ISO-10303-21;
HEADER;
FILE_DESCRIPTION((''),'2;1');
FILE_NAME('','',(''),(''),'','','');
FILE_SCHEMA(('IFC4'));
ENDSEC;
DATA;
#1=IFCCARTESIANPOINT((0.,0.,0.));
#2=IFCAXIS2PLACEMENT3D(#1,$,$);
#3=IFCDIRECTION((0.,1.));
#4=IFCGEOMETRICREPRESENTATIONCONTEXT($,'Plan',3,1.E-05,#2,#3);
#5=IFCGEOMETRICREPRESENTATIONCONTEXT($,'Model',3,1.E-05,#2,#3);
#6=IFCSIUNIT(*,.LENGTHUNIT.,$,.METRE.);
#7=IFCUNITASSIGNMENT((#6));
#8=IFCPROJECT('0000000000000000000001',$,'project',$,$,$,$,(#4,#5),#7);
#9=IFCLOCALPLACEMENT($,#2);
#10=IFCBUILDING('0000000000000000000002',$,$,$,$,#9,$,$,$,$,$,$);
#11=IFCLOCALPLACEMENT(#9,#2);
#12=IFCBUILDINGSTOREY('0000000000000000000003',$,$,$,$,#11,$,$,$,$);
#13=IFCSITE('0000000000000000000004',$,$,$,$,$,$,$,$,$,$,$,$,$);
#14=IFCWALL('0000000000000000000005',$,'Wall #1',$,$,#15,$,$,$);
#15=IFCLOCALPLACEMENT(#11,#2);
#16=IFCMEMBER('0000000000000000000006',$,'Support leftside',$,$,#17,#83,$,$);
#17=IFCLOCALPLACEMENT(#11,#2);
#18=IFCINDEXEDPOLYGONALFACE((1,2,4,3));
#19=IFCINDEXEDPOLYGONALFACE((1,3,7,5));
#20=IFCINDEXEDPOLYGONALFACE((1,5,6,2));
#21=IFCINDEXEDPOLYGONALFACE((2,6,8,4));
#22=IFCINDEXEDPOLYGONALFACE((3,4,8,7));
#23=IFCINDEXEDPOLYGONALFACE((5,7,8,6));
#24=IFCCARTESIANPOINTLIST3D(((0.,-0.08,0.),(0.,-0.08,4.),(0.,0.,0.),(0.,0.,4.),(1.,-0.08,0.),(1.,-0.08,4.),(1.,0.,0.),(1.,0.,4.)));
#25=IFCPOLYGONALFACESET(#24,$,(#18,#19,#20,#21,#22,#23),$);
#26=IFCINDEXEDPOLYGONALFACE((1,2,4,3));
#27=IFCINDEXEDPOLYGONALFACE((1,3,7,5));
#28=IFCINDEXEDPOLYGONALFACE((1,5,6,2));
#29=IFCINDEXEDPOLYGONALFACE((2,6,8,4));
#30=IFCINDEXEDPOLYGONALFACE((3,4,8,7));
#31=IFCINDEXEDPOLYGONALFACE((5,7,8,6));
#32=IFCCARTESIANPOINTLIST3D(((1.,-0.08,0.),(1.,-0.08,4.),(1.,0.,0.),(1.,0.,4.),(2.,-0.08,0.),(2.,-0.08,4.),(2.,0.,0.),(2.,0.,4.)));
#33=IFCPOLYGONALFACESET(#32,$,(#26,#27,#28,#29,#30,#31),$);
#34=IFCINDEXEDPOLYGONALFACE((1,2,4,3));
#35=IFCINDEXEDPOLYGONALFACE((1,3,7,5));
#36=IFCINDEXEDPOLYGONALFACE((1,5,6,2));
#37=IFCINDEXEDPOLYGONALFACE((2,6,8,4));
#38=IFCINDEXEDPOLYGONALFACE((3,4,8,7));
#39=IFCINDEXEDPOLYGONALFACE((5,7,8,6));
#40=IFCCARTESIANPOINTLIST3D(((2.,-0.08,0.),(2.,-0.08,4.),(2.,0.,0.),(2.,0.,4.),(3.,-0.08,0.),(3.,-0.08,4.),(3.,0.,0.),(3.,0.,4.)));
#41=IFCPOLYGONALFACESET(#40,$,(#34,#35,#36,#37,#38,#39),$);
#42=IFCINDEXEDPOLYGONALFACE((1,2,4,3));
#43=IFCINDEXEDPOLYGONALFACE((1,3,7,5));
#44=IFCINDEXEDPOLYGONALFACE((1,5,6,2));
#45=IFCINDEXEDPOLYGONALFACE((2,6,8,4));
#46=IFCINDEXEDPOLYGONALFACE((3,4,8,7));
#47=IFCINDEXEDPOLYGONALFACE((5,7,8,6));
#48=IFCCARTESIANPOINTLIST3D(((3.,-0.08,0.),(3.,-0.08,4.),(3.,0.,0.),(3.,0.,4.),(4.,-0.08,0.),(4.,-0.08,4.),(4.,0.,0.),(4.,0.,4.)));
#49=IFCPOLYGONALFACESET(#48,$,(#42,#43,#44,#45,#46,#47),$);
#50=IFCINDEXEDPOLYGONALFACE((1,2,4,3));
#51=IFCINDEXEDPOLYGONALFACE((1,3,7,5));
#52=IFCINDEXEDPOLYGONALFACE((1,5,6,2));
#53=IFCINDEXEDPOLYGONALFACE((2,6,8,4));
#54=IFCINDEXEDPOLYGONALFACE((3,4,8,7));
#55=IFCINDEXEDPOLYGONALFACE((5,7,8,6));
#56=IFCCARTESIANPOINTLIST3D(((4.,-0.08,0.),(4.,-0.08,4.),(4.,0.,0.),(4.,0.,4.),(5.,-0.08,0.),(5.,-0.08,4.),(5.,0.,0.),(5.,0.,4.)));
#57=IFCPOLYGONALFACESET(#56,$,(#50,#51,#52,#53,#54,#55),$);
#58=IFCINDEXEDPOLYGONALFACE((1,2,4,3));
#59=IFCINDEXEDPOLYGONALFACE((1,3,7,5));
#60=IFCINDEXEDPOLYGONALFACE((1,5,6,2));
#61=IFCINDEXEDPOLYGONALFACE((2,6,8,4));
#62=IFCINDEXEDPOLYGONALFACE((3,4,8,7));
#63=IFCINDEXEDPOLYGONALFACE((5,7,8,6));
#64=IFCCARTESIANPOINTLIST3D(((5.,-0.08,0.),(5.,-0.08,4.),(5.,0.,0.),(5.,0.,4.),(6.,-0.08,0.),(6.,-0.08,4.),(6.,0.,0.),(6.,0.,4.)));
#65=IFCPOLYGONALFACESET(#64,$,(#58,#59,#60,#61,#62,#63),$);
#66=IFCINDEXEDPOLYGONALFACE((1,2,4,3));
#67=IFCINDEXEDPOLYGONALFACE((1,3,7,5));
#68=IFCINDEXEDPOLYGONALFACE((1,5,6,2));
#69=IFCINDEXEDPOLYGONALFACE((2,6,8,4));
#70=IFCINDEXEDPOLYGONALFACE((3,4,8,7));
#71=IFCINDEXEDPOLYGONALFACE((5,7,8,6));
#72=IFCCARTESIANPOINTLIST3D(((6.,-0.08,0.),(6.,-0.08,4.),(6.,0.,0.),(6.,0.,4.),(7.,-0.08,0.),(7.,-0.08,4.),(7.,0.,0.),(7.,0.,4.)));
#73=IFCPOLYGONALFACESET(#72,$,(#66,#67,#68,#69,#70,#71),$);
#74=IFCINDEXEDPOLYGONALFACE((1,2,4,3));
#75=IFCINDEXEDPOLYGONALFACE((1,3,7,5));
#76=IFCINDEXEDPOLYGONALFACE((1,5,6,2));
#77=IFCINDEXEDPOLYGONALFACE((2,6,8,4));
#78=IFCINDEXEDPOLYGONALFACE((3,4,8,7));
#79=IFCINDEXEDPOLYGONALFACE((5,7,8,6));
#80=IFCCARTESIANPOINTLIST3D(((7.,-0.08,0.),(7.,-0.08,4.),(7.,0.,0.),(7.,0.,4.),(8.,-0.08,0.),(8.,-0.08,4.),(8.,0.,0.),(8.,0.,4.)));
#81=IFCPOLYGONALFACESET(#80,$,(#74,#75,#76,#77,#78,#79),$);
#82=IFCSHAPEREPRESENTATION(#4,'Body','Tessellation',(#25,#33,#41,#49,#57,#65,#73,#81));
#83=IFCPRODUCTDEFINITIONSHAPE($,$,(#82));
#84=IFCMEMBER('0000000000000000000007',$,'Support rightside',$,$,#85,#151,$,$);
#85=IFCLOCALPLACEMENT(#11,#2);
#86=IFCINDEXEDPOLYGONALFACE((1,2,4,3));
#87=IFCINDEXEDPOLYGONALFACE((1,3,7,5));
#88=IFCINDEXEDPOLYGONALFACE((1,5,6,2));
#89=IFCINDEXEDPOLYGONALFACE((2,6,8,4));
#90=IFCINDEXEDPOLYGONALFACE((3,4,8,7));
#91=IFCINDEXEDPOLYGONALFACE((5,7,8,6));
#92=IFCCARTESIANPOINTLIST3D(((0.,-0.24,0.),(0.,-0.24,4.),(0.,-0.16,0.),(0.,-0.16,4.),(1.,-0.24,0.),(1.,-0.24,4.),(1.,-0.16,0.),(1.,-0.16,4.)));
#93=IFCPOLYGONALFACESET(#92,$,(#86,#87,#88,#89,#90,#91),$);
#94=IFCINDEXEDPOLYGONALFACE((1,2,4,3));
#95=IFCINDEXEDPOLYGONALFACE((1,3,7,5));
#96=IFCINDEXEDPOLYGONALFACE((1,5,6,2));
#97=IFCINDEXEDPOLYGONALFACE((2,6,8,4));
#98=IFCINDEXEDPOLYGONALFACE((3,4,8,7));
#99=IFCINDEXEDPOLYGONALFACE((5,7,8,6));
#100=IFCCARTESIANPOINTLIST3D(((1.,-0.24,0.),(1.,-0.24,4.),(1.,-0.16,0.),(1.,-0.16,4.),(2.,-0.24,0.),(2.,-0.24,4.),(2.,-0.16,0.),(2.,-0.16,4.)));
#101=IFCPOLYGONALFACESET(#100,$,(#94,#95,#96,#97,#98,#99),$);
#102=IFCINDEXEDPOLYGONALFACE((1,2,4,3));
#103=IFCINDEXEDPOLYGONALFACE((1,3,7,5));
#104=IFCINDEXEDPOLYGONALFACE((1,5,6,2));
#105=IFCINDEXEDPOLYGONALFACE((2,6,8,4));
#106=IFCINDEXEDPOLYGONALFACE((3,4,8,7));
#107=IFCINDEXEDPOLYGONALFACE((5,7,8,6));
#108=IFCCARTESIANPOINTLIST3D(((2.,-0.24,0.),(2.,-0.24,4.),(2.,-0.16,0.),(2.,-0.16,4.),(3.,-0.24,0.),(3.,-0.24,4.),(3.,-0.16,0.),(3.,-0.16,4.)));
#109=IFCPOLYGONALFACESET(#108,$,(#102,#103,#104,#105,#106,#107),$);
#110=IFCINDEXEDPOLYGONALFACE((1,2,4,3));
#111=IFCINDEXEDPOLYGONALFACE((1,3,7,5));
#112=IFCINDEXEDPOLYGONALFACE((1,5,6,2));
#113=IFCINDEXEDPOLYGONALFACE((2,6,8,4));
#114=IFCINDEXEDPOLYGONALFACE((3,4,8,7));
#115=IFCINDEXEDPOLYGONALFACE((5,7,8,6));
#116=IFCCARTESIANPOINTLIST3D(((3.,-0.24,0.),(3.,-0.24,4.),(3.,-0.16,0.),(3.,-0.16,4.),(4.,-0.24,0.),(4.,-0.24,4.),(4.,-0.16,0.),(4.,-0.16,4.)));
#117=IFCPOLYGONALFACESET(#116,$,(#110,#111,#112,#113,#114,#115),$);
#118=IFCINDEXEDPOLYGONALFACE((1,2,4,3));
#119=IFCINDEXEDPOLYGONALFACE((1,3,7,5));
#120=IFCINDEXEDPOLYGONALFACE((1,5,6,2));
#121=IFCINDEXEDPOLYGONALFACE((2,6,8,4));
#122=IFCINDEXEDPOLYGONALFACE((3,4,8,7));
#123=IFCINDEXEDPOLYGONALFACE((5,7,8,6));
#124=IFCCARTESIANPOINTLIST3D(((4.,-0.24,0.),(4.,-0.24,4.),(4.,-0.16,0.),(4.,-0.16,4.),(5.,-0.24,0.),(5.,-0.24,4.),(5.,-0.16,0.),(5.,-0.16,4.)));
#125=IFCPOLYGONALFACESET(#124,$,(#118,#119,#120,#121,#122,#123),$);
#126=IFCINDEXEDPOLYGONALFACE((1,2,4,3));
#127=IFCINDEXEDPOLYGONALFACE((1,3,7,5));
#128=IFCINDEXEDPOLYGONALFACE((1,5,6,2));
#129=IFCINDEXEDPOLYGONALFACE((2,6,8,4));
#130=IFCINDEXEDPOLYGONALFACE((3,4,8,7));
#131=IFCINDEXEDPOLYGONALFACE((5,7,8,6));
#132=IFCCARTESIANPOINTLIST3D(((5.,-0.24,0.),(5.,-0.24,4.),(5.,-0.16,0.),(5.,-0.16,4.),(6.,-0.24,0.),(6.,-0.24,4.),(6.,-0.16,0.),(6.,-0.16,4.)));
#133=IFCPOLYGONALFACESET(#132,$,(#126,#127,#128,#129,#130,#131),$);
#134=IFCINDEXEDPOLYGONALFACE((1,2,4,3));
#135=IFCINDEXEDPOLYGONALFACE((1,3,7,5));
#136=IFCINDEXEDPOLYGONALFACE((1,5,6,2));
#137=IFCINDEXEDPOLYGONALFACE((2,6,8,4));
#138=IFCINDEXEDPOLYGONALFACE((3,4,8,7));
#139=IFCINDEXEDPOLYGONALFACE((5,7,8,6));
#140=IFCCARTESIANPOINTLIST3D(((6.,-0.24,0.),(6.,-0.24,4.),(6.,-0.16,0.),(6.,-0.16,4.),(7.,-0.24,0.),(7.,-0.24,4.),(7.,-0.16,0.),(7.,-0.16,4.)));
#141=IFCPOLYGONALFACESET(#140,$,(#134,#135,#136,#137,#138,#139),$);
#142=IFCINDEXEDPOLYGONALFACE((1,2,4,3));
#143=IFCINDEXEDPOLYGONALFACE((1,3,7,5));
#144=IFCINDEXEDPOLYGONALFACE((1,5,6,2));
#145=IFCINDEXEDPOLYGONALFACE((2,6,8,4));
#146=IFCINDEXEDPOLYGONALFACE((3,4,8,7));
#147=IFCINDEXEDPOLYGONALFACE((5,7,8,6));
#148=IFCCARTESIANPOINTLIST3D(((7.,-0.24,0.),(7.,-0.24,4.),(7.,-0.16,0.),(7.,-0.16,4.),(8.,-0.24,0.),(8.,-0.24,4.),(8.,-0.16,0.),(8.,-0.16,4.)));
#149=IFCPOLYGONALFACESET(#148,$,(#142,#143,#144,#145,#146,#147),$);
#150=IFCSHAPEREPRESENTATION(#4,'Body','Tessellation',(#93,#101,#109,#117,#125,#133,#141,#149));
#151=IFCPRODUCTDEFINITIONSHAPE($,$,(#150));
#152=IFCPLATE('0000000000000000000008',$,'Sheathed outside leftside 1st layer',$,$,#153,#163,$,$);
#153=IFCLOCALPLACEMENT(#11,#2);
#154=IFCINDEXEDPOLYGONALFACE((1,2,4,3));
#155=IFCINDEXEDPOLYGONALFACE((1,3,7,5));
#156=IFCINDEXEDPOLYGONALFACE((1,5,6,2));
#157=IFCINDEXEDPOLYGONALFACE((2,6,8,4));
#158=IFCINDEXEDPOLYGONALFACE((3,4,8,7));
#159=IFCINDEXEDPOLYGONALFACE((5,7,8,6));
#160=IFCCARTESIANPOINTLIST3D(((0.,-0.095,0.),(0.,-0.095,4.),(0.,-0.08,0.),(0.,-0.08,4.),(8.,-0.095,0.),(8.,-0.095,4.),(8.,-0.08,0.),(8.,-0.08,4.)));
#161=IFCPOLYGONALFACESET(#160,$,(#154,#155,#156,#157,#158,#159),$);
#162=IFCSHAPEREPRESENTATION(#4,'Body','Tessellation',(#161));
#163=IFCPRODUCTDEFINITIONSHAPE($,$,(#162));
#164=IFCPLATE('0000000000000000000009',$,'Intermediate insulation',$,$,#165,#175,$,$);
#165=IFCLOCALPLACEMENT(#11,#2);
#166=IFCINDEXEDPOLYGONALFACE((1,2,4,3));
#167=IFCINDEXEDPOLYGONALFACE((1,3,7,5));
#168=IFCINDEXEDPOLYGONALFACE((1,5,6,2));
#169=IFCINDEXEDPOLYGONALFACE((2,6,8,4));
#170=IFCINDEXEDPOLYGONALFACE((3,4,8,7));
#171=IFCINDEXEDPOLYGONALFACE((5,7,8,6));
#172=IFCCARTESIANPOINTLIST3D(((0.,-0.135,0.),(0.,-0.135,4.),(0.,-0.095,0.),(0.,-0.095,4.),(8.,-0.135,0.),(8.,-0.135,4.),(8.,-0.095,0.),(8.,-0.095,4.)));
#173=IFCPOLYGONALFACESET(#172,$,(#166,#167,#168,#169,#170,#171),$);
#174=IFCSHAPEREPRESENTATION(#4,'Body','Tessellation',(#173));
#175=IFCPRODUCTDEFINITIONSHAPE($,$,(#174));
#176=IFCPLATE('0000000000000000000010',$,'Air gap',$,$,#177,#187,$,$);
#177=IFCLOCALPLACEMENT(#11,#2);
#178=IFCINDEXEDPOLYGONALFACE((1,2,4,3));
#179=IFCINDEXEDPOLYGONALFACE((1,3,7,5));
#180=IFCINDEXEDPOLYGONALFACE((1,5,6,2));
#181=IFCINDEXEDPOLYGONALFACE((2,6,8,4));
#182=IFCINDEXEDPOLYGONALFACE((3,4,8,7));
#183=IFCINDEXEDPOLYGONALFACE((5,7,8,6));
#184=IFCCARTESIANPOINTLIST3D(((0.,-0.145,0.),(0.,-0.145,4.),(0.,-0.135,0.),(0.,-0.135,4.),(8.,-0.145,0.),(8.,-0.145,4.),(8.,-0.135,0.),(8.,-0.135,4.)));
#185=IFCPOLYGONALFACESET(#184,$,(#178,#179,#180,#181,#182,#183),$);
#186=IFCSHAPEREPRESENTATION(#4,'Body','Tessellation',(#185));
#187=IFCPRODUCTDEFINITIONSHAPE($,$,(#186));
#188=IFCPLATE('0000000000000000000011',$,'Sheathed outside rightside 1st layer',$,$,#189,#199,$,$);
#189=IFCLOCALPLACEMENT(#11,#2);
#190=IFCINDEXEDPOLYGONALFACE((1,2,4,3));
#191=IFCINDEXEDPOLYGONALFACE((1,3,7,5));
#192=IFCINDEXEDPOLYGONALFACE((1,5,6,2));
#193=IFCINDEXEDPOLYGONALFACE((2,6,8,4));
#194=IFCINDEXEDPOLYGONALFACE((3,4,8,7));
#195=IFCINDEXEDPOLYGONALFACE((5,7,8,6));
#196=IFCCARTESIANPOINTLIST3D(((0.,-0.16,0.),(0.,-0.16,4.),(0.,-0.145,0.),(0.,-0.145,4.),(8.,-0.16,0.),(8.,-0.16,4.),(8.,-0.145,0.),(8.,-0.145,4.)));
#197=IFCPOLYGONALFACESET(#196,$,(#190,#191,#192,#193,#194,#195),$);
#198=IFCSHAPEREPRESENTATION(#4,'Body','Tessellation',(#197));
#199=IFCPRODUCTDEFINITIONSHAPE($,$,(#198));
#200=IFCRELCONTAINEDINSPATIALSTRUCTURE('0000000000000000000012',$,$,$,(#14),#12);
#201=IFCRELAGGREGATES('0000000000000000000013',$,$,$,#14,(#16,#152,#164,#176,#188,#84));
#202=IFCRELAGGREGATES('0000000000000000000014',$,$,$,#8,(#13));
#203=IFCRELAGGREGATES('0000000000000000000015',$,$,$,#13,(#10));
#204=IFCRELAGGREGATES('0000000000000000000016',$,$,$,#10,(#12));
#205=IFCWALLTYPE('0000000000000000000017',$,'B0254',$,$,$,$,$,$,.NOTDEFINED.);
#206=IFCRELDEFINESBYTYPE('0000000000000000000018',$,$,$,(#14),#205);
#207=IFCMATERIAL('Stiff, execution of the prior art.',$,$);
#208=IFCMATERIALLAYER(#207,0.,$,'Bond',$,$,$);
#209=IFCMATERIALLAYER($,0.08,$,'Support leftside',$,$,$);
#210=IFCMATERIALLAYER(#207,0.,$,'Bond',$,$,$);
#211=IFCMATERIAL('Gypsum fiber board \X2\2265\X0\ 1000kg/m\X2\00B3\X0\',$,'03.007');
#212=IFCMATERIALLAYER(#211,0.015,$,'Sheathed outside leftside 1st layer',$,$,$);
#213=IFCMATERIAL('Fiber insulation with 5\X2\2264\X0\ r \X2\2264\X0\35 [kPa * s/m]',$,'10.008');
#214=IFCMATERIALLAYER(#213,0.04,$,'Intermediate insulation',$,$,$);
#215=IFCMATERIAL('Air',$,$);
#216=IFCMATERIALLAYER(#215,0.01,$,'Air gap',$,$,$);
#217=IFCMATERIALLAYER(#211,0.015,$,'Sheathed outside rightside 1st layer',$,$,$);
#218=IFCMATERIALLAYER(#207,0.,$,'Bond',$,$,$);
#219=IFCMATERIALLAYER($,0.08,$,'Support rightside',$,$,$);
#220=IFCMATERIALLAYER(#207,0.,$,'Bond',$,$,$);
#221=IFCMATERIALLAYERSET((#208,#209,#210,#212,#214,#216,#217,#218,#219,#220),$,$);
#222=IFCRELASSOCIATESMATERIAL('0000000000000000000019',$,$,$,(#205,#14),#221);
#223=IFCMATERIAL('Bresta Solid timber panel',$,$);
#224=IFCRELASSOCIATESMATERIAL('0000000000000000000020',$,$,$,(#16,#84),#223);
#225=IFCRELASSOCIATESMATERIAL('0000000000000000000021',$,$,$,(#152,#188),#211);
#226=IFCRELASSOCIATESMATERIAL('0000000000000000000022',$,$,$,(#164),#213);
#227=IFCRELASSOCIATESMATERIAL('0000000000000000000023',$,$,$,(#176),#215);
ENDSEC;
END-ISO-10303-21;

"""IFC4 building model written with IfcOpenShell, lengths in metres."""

from ifc_helpers import new_model, si_unit, direction, frame, frame_2d, origin, place, context, project, spatial, rectangle, extrude, material, layer, layer_set, type_object, element, aggregate, save


model = new_model("IFC4")

# Units and contexts
plan_context = context("Plan", 3, precision=1e-05, world=origin(), true_north=direction((0.0, 1.0)))
model_context = context("Model", 3, precision=1e-05, world=origin(), true_north=direction((0.0, 1.0)))
ifc_project = project(units=[si_unit("LENGTHUNIT", "METRE")], contexts=[plan_context, model_context])

# Site, building, storey
site = spatial("IfcSite", under=ifc_project)
building_placement = place(None, origin())
building = spatial("IfcBuilding", under=site, at=building_placement)
storey_placement = place(building_placement, origin())
storey = spatial("IfcBuildingStorey", under=building, at=storey_placement)

# Wall, members, plates
ifc_material_1 = material(Name="Stiff, execution of the prior art.")
ifc_layer_1 = layer(ifc_material_1, 0.0, Name="Bond")
ifc_layer_2 = layer(None, 0.08, Name="Support leftside")
ifc_layer_3 = layer(ifc_material_1, 0.0, Name="Bond")
ifc_material_2 = material(Name="Gypsum fiber board ≥ 1000kg/m³", Category="03.007")
ifc_layer_4 = layer(ifc_material_2, 0.015, Name="Sheathed outside leftside 1st layer")
ifc_material_3 = material(Name="Fiber insulation with 5≤ r ≤35 [kPa * s/m]", Category="10.008")
ifc_layer_5 = layer(ifc_material_3, 0.04, Name="Intermediate insulation")
ifc_material_4 = material(Name="Air")
ifc_layer_6 = layer(ifc_material_4, 0.01, Name="Air gap")
ifc_layer_7 = layer(ifc_material_2, 0.015, Name="Sheathed outside rightside 1st layer")
ifc_layer_8 = layer(ifc_material_1, 0.0, Name="Bond")
ifc_layer_9 = layer(None, 0.08, Name="Support rightside")
ifc_layer_10 = layer(ifc_material_1, 0.0, Name="Bond")
ifc_layer_set = layer_set([ifc_layer_1, ifc_layer_2, ifc_layer_3, ifc_layer_4, ifc_layer_5, ifc_layer_6, ifc_layer_7, ifc_layer_8, ifc_layer_9, ifc_layer_10])
wall_type = type_object("IfcWallType", Name="B0254", PredefinedType="NOTDEFINED", material=ifc_layer_set)
wall_placement = place(None, frame((0.0, 0.0, 0.0), z_axis=(0.0, -1.0, 0.0), x_axis=(1.0, 0.0, 0.0)))
wall = element("IfcWall", 1, at=wall_placement, inside=storey, type_object=wall_type, material=ifc_layer_set, Name="Wall #1")
ifc_material_5 = material(Name="Bresta Solid timber panel")
member_1_placement = place(wall_placement, origin())
member_1 = element("IfcMember", 2, at=member_1_placement, material=ifc_material_5, Name="Support leftside", context=plan_context, shape_type="SweptSolid", body=[
    extrude(rectangle(XDim=1.0, YDim=0.08, at=frame_2d((0.5, 0.04), x_axis=(1.0, 0.0))), frame((0.0, 4.0, 0.0), z_axis=(0.0, -1.0, 0.0), x_axis=(1.0, 0.0, 0.0)), (0.0, 0.0, 1.0), 4.0),
    extrude(rectangle(XDim=1.0, YDim=0.08, at=frame_2d((0.5, 0.04), x_axis=(1.0, 0.0))), frame((1.0, 4.0, 0.0), z_axis=(0.0, -1.0, 0.0), x_axis=(1.0, 0.0, 0.0)), (0.0, 0.0, 1.0), 4.0),
    extrude(rectangle(XDim=1.0, YDim=0.08, at=frame_2d((0.5, 0.04), x_axis=(1.0, 0.0))), frame((2.0, 4.0, 0.0), z_axis=(0.0, -1.0, 0.0), x_axis=(1.0, 0.0, 0.0)), (0.0, 0.0, 1.0), 4.0),
    extrude(rectangle(XDim=1.0, YDim=0.08, at=frame_2d((0.5, 0.04), x_axis=(1.0, 0.0))), frame((3.0, 4.0, 0.0), z_axis=(0.0, -1.0, 0.0), x_axis=(1.0, 0.0, 0.0)), (0.0, 0.0, 1.0), 4.0),
    extrude(rectangle(XDim=1.0, YDim=0.08, at=frame_2d((0.5, 0.04), x_axis=(1.0, 0.0))), frame((4.0, 4.0, 0.0), z_axis=(0.0, -1.0, 0.0), x_axis=(1.0, 0.0, 0.0)), (0.0, 0.0, 1.0), 4.0),
    extrude(rectangle(XDim=1.0, YDim=0.08, at=frame_2d((0.5, 0.04), x_axis=(1.0, 0.0))), frame((5.0, 4.0, 0.0), z_axis=(0.0, -1.0, 0.0), x_axis=(1.0, 0.0, 0.0)), (0.0, 0.0, 1.0), 4.0),
    extrude(rectangle(XDim=1.0, YDim=0.08, at=frame_2d((0.5, 0.04), x_axis=(1.0, 0.0))), frame((6.0, 4.0, 0.0), z_axis=(0.0, -1.0, 0.0), x_axis=(1.0, 0.0, 0.0)), (0.0, 0.0, 1.0), 4.0),
    extrude(rectangle(XDim=1.0, YDim=0.08, at=frame_2d((0.5, 0.04), x_axis=(1.0, 0.0))), frame((7.0, 4.0, 0.0), z_axis=(0.0, -1.0, 0.0), x_axis=(1.0, 0.0, 0.0)), (0.0, 0.0, 1.0), 4.0),
])
member_2_placement = place(wall_placement, origin())
member_2 = element("IfcMember", 3, at=member_2_placement, material=ifc_material_5, Name="Support rightside", context=plan_context, shape_type="SweptSolid", body=[
    extrude(rectangle(XDim=1.0, YDim=0.08, at=frame_2d((0.5, 0.04), x_axis=(1.0, 0.0))), frame((0.0, 4.0, 0.16), z_axis=(0.0, -1.0, 0.0), x_axis=(1.0, 0.0, 0.0)), (0.0, 0.0, 1.0), 4.0),
    extrude(rectangle(XDim=1.0, YDim=0.08, at=frame_2d((0.5, 0.04), x_axis=(1.0, 0.0))), frame((1.0, 4.0, 0.16), z_axis=(0.0, -1.0, 0.0), x_axis=(1.0, 0.0, 0.0)), (0.0, 0.0, 1.0), 4.0),
    extrude(rectangle(XDim=1.0, YDim=0.08, at=frame_2d((0.5, 0.04), x_axis=(1.0, 0.0))), frame((2.0, 4.0, 0.16), z_axis=(0.0, -1.0, 0.0), x_axis=(1.0, 0.0, 0.0)), (0.0, 0.0, 1.0), 4.0),
    extrude(rectangle(XDim=1.0, YDim=0.08, at=frame_2d((0.5, 0.04), x_axis=(1.0, 0.0))), frame((3.0, 4.0, 0.16), z_axis=(0.0, -1.0, 0.0), x_axis=(1.0, 0.0, 0.0)), (0.0, 0.0, 1.0), 4.0),
    extrude(rectangle(XDim=1.0, YDim=0.08, at=frame_2d((0.5, 0.04), x_axis=(1.0, 0.0))), frame((4.0, 4.0, 0.16), z_axis=(0.0, -1.0, 0.0), x_axis=(1.0, 0.0, 0.0)), (0.0, 0.0, 1.0), 4.0),
    extrude(rectangle(XDim=1.0, YDim=0.08, at=frame_2d((0.5, 0.04), x_axis=(1.0, 0.0))), frame((5.0, 4.0, 0.16), z_axis=(0.0, -1.0, 0.0), x_axis=(1.0, 0.0, 0.0)), (0.0, 0.0, 1.0), 4.0),
    extrude(rectangle(XDim=1.0, YDim=0.08, at=frame_2d((0.5, 0.04), x_axis=(1.0, 0.0))), frame((6.0, 4.0, 0.16), z_axis=(0.0, -1.0, 0.0), x_axis=(1.0, 0.0, 0.0)), (0.0, 0.0, 1.0), 4.0),
    extrude(rectangle(XDim=1.0, YDim=0.08, at=frame_2d((0.5, 0.04), x_axis=(1.0, 0.0))), frame((7.0, 4.0, 0.16), z_axis=(0.0, -1.0, 0.0), x_axis=(1.0, 0.0, 0.0)), (0.0, 0.0, 1.0), 4.0),
])
plate_1_placement = place(wall_placement, origin())
plate_1 = element("IfcPlate", 4, at=plate_1_placement, material=ifc_material_2, Name="Sheathed outside leftside 1st layer", context=plan_context, shape_type="SweptSolid", body=[
    extrude(rectangle(XDim=8.0, YDim=4.0, at=frame_2d((4.0, 2.0), x_axis=(1.0, 0.0))), frame((0.0, 0.0, 0.08), z_axis=(0.0, 0.0, 1.0), x_axis=(1.0, 0.0, 0.0)), (0.0, 0.0, 1.0), 0.015),
])
plate_2_placement = place(wall_placement, origin())
plate_2 = element("IfcPlate", 5, at=plate_2_placement, material=ifc_material_3, Name="Intermediate insulation", context=plan_context, shape_type="SweptSolid", body=[
    extrude(rectangle(XDim=8.0, YDim=4.0, at=frame_2d((4.0, 2.0), x_axis=(1.0, 0.0))), frame((0.0, 0.0, 0.095), z_axis=(0.0, 0.0, 1.0), x_axis=(1.0, 0.0, 0.0)), (0.0, 0.0, 1.0), 0.04),
])
plate_3_placement = place(wall_placement, origin())
plate_3 = element("IfcPlate", 6, at=plate_3_placement, material=ifc_material_4, Name="Air gap", context=plan_context, shape_type="SweptSolid", body=[
    extrude(rectangle(XDim=8.0, YDim=4.0, at=frame_2d((4.0, 2.0), x_axis=(1.0, 0.0))), frame((0.0, 0.0, 0.135), z_axis=(0.0, 0.0, 1.0), x_axis=(1.0, 0.0, 0.0)), (0.0, 0.0, 1.0), 0.01),
])
plate_4_placement = place(wall_placement, origin())
plate_4 = element("IfcPlate", 7, at=plate_4_placement, material=ifc_material_2, Name="Sheathed outside rightside 1st layer", context=plan_context, shape_type="SweptSolid", body=[
    extrude(rectangle(XDim=8.0, YDim=4.0, at=frame_2d((4.0, 2.0), x_axis=(1.0, 0.0))), frame((0.0, 0.0, 0.145), z_axis=(0.0, 0.0, 1.0), x_axis=(1.0, 0.0, 0.0)), (0.0, 0.0, 1.0), 0.015),
])
aggregate(wall, [member_1, plate_1, plate_2, plate_3, plate_4, member_2])

save(model, "model.ifc")
